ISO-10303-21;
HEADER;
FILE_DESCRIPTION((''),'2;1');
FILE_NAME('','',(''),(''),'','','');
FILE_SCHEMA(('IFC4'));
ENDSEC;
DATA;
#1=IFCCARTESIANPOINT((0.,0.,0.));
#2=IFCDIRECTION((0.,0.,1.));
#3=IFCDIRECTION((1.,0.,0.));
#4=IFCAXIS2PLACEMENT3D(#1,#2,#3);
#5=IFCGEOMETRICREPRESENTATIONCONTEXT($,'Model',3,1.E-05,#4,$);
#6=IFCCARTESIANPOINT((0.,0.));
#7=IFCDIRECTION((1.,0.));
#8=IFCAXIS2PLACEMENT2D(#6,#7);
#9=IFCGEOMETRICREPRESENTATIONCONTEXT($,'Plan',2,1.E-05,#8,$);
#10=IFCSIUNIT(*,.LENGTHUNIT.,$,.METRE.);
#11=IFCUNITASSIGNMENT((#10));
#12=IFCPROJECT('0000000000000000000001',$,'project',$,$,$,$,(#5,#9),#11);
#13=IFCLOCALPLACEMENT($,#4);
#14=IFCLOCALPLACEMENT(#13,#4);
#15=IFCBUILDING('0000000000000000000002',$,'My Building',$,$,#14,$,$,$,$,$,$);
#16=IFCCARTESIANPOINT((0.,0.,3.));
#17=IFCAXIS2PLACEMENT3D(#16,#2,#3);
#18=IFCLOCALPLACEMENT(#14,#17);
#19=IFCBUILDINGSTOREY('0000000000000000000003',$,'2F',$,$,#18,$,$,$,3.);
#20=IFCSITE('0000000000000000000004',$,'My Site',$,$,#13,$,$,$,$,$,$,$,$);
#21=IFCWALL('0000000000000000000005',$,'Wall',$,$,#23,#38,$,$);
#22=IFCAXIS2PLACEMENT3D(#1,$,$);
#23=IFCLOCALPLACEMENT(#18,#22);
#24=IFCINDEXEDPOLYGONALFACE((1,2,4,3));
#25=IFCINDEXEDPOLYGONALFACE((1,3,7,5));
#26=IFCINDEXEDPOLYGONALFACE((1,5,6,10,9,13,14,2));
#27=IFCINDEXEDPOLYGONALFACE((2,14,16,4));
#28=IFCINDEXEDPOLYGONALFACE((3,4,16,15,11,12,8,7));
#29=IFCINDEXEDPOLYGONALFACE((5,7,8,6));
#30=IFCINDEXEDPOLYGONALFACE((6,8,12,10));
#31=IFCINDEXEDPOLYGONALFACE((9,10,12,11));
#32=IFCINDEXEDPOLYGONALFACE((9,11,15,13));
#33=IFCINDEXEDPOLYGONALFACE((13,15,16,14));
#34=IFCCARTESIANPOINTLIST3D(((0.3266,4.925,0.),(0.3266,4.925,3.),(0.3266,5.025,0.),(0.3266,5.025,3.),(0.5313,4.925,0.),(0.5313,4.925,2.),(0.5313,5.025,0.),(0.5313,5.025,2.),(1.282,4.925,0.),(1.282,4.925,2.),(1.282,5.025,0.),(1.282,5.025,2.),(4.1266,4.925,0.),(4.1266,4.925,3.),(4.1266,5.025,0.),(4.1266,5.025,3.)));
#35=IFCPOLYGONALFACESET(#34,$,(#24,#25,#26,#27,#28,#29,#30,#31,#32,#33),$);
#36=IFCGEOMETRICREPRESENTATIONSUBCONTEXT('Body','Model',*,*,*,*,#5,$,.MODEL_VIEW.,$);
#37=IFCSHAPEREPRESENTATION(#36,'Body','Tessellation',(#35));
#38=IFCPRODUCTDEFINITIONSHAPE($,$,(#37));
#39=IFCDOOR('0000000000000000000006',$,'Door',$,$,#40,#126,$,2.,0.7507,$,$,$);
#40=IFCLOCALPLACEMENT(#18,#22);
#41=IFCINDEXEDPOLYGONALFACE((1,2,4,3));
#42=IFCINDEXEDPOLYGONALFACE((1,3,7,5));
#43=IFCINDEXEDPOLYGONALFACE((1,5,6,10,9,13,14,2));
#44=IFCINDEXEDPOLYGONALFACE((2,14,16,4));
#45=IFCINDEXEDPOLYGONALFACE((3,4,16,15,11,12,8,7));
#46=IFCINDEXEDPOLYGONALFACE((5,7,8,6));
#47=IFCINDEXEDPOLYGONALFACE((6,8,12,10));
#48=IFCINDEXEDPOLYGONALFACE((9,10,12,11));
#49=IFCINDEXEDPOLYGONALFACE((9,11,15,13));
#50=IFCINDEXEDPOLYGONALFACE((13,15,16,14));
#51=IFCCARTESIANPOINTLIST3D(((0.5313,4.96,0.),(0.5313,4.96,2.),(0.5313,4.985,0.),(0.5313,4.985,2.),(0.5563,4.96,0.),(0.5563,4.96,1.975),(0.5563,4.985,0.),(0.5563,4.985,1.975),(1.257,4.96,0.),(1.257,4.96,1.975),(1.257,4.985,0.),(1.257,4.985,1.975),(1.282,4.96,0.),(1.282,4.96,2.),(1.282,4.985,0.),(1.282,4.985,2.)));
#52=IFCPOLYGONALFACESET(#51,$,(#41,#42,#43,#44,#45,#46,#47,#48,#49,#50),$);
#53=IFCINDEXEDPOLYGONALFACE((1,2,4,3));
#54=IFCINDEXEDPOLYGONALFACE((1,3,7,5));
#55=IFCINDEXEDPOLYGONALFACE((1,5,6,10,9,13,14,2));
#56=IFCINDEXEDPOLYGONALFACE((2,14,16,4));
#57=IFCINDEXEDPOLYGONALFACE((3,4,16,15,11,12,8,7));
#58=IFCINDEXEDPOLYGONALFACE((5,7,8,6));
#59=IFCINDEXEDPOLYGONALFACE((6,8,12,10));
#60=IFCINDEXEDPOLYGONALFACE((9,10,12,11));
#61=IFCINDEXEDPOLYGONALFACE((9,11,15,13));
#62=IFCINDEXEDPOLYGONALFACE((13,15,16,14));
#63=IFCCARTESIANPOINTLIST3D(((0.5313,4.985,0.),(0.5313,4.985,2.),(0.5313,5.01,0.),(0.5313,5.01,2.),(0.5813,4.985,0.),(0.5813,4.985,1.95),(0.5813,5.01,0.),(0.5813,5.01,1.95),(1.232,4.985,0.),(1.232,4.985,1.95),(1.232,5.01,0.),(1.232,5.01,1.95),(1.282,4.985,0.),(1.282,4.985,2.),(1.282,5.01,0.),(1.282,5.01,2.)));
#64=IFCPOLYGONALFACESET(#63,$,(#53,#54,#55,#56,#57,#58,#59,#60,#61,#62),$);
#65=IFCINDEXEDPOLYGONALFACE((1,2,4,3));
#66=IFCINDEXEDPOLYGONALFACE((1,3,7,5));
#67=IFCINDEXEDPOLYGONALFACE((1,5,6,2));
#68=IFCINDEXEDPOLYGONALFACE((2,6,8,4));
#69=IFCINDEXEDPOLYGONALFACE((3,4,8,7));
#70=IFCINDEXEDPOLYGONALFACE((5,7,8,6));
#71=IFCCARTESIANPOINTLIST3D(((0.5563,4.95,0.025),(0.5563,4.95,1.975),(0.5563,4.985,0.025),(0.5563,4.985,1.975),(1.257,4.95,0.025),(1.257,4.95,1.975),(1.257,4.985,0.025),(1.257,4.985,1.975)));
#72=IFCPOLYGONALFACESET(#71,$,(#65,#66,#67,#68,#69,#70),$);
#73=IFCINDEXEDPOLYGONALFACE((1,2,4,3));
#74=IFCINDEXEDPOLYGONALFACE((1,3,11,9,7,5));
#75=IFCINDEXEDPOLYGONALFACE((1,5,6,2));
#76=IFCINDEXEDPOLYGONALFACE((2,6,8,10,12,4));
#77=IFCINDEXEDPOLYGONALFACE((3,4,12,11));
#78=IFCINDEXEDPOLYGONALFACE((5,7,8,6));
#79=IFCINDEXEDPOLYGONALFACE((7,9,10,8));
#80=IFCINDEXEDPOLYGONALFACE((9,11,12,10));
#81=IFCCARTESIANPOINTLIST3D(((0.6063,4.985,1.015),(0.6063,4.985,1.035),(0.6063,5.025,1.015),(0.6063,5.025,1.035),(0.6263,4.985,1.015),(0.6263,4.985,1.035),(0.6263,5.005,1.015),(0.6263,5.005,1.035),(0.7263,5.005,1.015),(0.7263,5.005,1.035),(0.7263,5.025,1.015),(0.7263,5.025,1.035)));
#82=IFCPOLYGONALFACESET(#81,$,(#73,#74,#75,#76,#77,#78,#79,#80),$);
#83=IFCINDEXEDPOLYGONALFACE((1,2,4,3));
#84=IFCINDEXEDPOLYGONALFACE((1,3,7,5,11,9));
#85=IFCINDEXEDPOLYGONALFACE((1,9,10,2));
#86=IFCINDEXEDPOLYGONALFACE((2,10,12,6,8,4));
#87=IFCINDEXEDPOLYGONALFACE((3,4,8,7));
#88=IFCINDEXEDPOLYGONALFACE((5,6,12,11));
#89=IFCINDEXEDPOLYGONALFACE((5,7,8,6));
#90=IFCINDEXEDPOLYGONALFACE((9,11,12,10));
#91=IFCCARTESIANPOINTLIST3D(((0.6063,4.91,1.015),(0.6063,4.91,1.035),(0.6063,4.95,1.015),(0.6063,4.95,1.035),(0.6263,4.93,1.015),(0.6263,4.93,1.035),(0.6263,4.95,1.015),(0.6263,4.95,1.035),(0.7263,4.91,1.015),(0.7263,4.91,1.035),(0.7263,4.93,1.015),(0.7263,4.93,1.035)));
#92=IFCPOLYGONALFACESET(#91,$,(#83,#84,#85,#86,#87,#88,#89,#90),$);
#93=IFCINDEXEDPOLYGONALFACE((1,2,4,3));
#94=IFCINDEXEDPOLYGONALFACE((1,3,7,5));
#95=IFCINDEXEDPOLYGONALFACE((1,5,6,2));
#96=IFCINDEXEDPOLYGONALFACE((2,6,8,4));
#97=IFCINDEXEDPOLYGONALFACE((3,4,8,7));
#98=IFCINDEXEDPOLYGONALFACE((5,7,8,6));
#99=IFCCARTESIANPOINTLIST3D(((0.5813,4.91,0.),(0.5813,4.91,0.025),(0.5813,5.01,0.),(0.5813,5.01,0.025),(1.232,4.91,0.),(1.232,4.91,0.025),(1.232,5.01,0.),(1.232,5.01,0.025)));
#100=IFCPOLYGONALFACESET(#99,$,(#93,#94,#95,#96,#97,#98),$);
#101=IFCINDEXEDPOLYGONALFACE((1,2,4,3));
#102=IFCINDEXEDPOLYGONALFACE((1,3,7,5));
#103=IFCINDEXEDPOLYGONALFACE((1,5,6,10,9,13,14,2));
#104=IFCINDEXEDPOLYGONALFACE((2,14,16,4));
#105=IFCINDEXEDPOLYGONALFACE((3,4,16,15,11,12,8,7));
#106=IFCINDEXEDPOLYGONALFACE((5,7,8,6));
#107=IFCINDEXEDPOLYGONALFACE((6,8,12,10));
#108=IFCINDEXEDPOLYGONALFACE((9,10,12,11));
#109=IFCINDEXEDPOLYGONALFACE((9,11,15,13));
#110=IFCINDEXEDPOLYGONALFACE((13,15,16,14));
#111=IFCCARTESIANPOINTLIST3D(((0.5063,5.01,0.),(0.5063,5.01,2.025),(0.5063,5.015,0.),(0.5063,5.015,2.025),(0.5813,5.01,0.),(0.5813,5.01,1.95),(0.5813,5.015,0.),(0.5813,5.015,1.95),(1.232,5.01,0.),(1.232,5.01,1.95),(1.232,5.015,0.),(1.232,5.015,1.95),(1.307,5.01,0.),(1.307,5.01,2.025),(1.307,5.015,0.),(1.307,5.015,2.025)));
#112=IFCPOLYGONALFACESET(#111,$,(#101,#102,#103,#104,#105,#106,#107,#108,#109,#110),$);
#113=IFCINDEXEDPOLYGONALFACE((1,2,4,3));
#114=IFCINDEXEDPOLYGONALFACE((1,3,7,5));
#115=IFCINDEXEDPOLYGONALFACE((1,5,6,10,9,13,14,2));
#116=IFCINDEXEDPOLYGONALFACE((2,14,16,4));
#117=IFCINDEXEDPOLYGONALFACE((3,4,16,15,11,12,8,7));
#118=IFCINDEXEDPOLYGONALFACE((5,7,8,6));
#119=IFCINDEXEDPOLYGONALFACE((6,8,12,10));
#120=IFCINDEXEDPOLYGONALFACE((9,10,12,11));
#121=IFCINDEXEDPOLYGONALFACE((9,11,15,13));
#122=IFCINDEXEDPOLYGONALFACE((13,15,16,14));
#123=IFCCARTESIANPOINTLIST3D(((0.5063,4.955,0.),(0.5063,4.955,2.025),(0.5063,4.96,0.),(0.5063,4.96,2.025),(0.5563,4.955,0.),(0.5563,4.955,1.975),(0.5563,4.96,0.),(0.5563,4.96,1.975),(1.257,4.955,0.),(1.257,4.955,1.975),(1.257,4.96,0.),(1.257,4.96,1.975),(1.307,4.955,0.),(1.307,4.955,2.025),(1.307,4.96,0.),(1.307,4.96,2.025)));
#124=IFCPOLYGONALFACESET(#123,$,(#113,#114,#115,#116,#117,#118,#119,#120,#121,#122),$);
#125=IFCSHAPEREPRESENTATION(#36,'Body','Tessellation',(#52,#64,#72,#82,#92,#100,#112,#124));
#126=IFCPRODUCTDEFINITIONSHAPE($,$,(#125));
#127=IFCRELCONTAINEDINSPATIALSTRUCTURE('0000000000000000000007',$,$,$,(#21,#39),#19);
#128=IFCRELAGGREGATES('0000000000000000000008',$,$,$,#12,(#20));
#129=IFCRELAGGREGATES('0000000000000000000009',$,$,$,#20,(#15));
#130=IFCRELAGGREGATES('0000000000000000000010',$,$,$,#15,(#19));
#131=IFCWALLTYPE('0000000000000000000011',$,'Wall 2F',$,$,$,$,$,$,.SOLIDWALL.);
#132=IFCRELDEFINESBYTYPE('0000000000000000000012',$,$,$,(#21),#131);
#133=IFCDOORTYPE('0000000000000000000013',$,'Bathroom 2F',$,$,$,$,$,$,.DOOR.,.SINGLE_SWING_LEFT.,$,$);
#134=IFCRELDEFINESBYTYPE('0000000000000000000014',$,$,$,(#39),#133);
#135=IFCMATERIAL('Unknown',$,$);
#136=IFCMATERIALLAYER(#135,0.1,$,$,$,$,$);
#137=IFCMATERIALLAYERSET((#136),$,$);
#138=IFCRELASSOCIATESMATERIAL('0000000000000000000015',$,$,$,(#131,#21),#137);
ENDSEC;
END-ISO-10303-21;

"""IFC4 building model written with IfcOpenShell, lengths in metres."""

from ifc_helpers import new_model, entity, si_unit, frame, origin_with_axes, origin_2d_with_axis, place, context, subcontext, project, spatial, polyline, line, indexed_curve, outline, extrude, shape, source, transform, mapped, material, layer, layer_set, layer_usage, type_object, type_shapes, element, fill, save


model = new_model("IFC4")

# Units and contexts
model_context = context("Model", 3, precision=1e-05, world=origin_with_axes())
plan_context = context("Plan", 2, precision=1e-05, world=origin_2d_with_axis())
body_context_1 = subcontext(model_context, "Body", "Model", "MODEL_VIEW")
body_context_2 = subcontext(plan_context, "Body", "Plan", "PLAN_VIEW")
ifc_project = project(units=[si_unit("LENGTHUNIT", "METRE")], contexts=[model_context, plan_context])

# Site, building, storey
site_placement = place(None, origin_with_axes())
site = spatial("IfcSite", under=ifc_project, at=site_placement, Name="My Site")
building_placement = place(site_placement, origin_with_axes())
building = spatial("IfcBuilding", under=site, at=building_placement, Name="My Building")
storey_placement = place(building_placement, frame((0.0, 0.0, 3.0), z_axis=(0.0, 0.0, 1.0), x_axis=(1.0, 0.0, 0.0)))
storey = spatial("IfcBuildingStorey", under=building, at=storey_placement, Name="2F", Elevation=3.0)

# Shared definitions
ifc_material = material(Name="Unknown")

# Shared definitions
ifc_layer_1 = layer(ifc_material, 0.1)
ifc_layer_set_1 = layer_set([ifc_layer_1])
wall_type = type_object("IfcWallType", Name="Wall 2F", PredefinedType="SOLIDWALL", material=ifc_layer_set_1)

# Wall, opening, door
ifc_layer_usage_1 = layer_usage(ifc_layer_set_1, "AXIS2", "POSITIVE", 0.0)
wall_1_placement = place(storey_placement, frame((4.1266, 5.025, 0.0), z_axis=(0.0, 0.0, 1.0), x_axis=(-1.0, 0.0, 0.0)))
wall_1 = element("IfcWall", 1, at=wall_1_placement, inside=storey, type_object=wall_type, material=ifc_layer_usage_1, Name="Wall", context=body_context_1, shape_type="SweptSolid", body=[
    extrude(outline(polyline([(0.0, 0.0), (3.8, 0.0), (3.8, 0.1), (0.0, 0.1), (0.0, 0.0)])), origin_with_axes(), (0.0, 0.0, 1.0), 3.0),
])
opening_1_placement = place(wall_1_placement, frame((2.8447, 0.015, 0.0), z_axis=(0.0, 0.0, 1.0), x_axis=(1.0, 0.0, 0.0)))
opening_1 = element("IfcOpeningElement", 2, at=opening_1_placement, cuts=wall_1, PredefinedType="OPENING", context=body_context_1, shape_type="SweptSolid", body=[
    extrude(outline(polyline([(0.0, 0.0), (0.7507, 0.0), (0.7507, 2.0), (0.0, 2.0), (0.0, 0.0)])), frame((0.0, -0.6, 0.0), z_axis=(0.0, -1.0, 0.0), x_axis=(1.0, 0.0, 0.0)), (0.0, 0.0, -1.0), 1.2),
])
door_type_1 = type_object("IfcDoorType", Name="Bathroom 2F", OperationType="SINGLE_SWING_LEFT", PredefinedType="DOOR")
shared_shape_1 = source(origin_with_axes(), body_context_1, "Body", "SweptSolid", [
    extrude(outline(indexed_curve([(0.0, 0.0), (0.0, 2.0), (0.7507, 2.0), (0.7507, 0.0), (0.7257, 0.0), (0.7257, 1.975), (0.025, 1.975), (0.025, 0.0)], segments=[line(1, 2, 3, 4, 5, 6, 7, 8, 1)])), frame((0.0, 0.025, 0.0), z_axis=(0.0, -1.0, 0.0), x_axis=(1.0, 0.0, 0.0)), (0.0, 0.0, -1.0), 0.025),
    extrude(outline(indexed_curve([(0.0, 0.0), (0.0, 2.0), (0.7507, 2.0), (0.7507, 0.0), (0.7007, 0.0), (0.7007, 1.95), (0.05, 1.95), (0.05, 0.0)], segments=[line(1, 2, 3, 4, 5, 6, 7, 8, 1)])), frame((0.0, 0.0, 0.0), z_axis=(0.0, -1.0, 0.0), x_axis=(1.0, 0.0, 0.0)), (0.0, 0.0, -1.0), 0.025),
    extrude(outline(indexed_curve([(0.0, 0.0), (0.7007, 0.0), (0.7007, 0.035), (0.0, 0.035)], segments=[line(1, 2, 3, 4, 1)])), frame((0.025, 0.025, 0.025), z_axis=(0.0, 0.0, 1.0), x_axis=(1.0, 0.0, 0.0)), (0.0, 0.0, 1.0), 1.95),
    extrude(outline(indexed_curve([(0.0, 0.0), (0.0, -0.04), (-0.12, -0.04), (-0.12, -0.02), (-0.02, -0.02), (-0.02, 0.0)], segments=[line(1, 2, 3, 4, 5, 6, 1)])), frame((0.6757, 0.025, 1.015), z_axis=(0.0, 0.0, 1.0), x_axis=(1.0, 0.0, 0.0)), (0.0, 0.0, 1.0), 0.02),
    extrude(outline(indexed_curve([(0.0, 0.0), (0.0, 0.04), (-0.12, 0.04), (-0.12, 0.02), (-0.02, 0.02), (-0.02, 0.0)], segments=[line(1, 2, 3, 4, 5, 6, 1)])), frame((0.6757, 0.06, 1.015), z_axis=(0.0, 0.0, 1.0), x_axis=(1.0, 0.0, 0.0)), (0.0, 0.0, 1.0), 0.02),
    extrude(outline(indexed_curve([(0.0, 0.0), (0.6507, 0.0), (0.6507, 0.1), (0.0, 0.1)], segments=[line(1, 2, 3, 4, 1)])), frame((0.05, 0.0, 0.0), z_axis=(0.0, 0.0, 1.0), x_axis=(1.0, 0.0, 0.0)), (0.0, 0.0, 1.0), 0.025),
    extrude(outline(indexed_curve([(0.0, 0.0), (0.0, 2.025), (0.8007, 2.025), (0.8007, 0.0), (0.7257, 0.0), (0.7257, 1.95), (0.075, 1.95), (0.075, 0.0)], segments=[line(1, 2, 3, 4, 5, 6, 7, 8, 1)])), frame((-0.025, -0.005, 0.0), z_axis=(0.0, -1.0, 0.0), x_axis=(1.0, 0.0, 0.0)), (0.0, 0.0, -1.0), 0.005),
    extrude(outline(indexed_curve([(0.0, 0.0), (0.0, 2.025), (0.8007, 2.025), (0.8007, 0.0), (0.7507, 0.0), (0.7507, 1.975), (0.05, 1.975), (0.05, 0.0)], segments=[line(1, 2, 3, 4, 5, 6, 7, 8, 1)])), frame((-0.025, 0.05, 0.0), z_axis=(0.0, -1.0, 0.0), x_axis=(1.0, 0.0, 0.0)), (0.0, 0.0, -1.0), 0.005),
])
shared_shape_2 = source(origin_with_axes(), body_context_2, "Body", "Curve2D", [
    entity("IfcIndexedPolyCurve", entity("IfcCartesianPointList2D", [[0.0, 0.0], [0.0, 0.05], [0.025, 0.05], [0.025, 0.025], [0.05, 0.025], [0.05, 0.0]]), [entity("IfcLineIndex", [1, 2, 3, 4, 5, 6, 1])]),
    entity("IfcIndexedPolyCurve", entity("IfcCartesianPointList2D", [[0.7507, 0.0], [0.7507, 0.05], [0.7257, 0.05], [0.7257, 0.025], [0.7007, 0.025], [0.7007, 0.0]]), [entity("IfcLineIndex", [1, 2, 3, 4, 5, 6, 1])]),
    entity("IfcTrimmedCurve", entity("IfcEllipse", entity("IfcAxis2Placement2D", entity("IfcCartesianPoint", [0.06, 0.05]), entity("IfcDirection", [1.0, 0.0])), 0.6657, 0.7007), [entity("IfcCartesianPoint", [0.7257, 0.05])], [entity("IfcCartesianPoint", [0.06, 0.7507])], True, "CARTESIAN"),
    entity("IfcIndexedPolyCurve", entity("IfcCartesianPointList2D", [[0.025, 0.05], [0.06, 0.05], [0.06, 0.7507], [0.025, 0.7507]]), [entity("IfcLineIndex", [1, 2, 3, 4, 1])]),
])
type_shapes(door_type_1, [shared_shape_1, shared_shape_2])
door_1_placement = place(storey_placement, frame((1.282, 5.01, 0.0), z_axis=(0.0, 0.0, 1.0), x_axis=(-1.0, 0.0, 0.0)))
door_1 = element("IfcDoor", 3, at=door_1_placement, inside=storey, type_object=door_type_1, Name="Door", OverallHeight=2.0, OverallWidth=0.7507, shapes=[
    shape(body_context_1, "Body", "MappedRepresentation", [mapped(shared_shape_1, transform((0.0, 0.0, 0.0), x_axis=(1.0, 0.0, 0.0), y_axis=(0.0, 1.0, 0.0), z_axis=(0.0, 0.0, 1.0), scale=1.0))]),
    shape(body_context_2, "Body", "MappedRepresentation", [mapped(shared_shape_2, transform((0.0, 0.0, 0.0), x_axis=(1.0, 0.0, 0.0), y_axis=(0.0, 1.0, 0.0), z_axis=(0.0, 0.0, 1.0), scale=1.0))]),
])
fill(opening_1, door_1)

save(model, "model.ifc")
